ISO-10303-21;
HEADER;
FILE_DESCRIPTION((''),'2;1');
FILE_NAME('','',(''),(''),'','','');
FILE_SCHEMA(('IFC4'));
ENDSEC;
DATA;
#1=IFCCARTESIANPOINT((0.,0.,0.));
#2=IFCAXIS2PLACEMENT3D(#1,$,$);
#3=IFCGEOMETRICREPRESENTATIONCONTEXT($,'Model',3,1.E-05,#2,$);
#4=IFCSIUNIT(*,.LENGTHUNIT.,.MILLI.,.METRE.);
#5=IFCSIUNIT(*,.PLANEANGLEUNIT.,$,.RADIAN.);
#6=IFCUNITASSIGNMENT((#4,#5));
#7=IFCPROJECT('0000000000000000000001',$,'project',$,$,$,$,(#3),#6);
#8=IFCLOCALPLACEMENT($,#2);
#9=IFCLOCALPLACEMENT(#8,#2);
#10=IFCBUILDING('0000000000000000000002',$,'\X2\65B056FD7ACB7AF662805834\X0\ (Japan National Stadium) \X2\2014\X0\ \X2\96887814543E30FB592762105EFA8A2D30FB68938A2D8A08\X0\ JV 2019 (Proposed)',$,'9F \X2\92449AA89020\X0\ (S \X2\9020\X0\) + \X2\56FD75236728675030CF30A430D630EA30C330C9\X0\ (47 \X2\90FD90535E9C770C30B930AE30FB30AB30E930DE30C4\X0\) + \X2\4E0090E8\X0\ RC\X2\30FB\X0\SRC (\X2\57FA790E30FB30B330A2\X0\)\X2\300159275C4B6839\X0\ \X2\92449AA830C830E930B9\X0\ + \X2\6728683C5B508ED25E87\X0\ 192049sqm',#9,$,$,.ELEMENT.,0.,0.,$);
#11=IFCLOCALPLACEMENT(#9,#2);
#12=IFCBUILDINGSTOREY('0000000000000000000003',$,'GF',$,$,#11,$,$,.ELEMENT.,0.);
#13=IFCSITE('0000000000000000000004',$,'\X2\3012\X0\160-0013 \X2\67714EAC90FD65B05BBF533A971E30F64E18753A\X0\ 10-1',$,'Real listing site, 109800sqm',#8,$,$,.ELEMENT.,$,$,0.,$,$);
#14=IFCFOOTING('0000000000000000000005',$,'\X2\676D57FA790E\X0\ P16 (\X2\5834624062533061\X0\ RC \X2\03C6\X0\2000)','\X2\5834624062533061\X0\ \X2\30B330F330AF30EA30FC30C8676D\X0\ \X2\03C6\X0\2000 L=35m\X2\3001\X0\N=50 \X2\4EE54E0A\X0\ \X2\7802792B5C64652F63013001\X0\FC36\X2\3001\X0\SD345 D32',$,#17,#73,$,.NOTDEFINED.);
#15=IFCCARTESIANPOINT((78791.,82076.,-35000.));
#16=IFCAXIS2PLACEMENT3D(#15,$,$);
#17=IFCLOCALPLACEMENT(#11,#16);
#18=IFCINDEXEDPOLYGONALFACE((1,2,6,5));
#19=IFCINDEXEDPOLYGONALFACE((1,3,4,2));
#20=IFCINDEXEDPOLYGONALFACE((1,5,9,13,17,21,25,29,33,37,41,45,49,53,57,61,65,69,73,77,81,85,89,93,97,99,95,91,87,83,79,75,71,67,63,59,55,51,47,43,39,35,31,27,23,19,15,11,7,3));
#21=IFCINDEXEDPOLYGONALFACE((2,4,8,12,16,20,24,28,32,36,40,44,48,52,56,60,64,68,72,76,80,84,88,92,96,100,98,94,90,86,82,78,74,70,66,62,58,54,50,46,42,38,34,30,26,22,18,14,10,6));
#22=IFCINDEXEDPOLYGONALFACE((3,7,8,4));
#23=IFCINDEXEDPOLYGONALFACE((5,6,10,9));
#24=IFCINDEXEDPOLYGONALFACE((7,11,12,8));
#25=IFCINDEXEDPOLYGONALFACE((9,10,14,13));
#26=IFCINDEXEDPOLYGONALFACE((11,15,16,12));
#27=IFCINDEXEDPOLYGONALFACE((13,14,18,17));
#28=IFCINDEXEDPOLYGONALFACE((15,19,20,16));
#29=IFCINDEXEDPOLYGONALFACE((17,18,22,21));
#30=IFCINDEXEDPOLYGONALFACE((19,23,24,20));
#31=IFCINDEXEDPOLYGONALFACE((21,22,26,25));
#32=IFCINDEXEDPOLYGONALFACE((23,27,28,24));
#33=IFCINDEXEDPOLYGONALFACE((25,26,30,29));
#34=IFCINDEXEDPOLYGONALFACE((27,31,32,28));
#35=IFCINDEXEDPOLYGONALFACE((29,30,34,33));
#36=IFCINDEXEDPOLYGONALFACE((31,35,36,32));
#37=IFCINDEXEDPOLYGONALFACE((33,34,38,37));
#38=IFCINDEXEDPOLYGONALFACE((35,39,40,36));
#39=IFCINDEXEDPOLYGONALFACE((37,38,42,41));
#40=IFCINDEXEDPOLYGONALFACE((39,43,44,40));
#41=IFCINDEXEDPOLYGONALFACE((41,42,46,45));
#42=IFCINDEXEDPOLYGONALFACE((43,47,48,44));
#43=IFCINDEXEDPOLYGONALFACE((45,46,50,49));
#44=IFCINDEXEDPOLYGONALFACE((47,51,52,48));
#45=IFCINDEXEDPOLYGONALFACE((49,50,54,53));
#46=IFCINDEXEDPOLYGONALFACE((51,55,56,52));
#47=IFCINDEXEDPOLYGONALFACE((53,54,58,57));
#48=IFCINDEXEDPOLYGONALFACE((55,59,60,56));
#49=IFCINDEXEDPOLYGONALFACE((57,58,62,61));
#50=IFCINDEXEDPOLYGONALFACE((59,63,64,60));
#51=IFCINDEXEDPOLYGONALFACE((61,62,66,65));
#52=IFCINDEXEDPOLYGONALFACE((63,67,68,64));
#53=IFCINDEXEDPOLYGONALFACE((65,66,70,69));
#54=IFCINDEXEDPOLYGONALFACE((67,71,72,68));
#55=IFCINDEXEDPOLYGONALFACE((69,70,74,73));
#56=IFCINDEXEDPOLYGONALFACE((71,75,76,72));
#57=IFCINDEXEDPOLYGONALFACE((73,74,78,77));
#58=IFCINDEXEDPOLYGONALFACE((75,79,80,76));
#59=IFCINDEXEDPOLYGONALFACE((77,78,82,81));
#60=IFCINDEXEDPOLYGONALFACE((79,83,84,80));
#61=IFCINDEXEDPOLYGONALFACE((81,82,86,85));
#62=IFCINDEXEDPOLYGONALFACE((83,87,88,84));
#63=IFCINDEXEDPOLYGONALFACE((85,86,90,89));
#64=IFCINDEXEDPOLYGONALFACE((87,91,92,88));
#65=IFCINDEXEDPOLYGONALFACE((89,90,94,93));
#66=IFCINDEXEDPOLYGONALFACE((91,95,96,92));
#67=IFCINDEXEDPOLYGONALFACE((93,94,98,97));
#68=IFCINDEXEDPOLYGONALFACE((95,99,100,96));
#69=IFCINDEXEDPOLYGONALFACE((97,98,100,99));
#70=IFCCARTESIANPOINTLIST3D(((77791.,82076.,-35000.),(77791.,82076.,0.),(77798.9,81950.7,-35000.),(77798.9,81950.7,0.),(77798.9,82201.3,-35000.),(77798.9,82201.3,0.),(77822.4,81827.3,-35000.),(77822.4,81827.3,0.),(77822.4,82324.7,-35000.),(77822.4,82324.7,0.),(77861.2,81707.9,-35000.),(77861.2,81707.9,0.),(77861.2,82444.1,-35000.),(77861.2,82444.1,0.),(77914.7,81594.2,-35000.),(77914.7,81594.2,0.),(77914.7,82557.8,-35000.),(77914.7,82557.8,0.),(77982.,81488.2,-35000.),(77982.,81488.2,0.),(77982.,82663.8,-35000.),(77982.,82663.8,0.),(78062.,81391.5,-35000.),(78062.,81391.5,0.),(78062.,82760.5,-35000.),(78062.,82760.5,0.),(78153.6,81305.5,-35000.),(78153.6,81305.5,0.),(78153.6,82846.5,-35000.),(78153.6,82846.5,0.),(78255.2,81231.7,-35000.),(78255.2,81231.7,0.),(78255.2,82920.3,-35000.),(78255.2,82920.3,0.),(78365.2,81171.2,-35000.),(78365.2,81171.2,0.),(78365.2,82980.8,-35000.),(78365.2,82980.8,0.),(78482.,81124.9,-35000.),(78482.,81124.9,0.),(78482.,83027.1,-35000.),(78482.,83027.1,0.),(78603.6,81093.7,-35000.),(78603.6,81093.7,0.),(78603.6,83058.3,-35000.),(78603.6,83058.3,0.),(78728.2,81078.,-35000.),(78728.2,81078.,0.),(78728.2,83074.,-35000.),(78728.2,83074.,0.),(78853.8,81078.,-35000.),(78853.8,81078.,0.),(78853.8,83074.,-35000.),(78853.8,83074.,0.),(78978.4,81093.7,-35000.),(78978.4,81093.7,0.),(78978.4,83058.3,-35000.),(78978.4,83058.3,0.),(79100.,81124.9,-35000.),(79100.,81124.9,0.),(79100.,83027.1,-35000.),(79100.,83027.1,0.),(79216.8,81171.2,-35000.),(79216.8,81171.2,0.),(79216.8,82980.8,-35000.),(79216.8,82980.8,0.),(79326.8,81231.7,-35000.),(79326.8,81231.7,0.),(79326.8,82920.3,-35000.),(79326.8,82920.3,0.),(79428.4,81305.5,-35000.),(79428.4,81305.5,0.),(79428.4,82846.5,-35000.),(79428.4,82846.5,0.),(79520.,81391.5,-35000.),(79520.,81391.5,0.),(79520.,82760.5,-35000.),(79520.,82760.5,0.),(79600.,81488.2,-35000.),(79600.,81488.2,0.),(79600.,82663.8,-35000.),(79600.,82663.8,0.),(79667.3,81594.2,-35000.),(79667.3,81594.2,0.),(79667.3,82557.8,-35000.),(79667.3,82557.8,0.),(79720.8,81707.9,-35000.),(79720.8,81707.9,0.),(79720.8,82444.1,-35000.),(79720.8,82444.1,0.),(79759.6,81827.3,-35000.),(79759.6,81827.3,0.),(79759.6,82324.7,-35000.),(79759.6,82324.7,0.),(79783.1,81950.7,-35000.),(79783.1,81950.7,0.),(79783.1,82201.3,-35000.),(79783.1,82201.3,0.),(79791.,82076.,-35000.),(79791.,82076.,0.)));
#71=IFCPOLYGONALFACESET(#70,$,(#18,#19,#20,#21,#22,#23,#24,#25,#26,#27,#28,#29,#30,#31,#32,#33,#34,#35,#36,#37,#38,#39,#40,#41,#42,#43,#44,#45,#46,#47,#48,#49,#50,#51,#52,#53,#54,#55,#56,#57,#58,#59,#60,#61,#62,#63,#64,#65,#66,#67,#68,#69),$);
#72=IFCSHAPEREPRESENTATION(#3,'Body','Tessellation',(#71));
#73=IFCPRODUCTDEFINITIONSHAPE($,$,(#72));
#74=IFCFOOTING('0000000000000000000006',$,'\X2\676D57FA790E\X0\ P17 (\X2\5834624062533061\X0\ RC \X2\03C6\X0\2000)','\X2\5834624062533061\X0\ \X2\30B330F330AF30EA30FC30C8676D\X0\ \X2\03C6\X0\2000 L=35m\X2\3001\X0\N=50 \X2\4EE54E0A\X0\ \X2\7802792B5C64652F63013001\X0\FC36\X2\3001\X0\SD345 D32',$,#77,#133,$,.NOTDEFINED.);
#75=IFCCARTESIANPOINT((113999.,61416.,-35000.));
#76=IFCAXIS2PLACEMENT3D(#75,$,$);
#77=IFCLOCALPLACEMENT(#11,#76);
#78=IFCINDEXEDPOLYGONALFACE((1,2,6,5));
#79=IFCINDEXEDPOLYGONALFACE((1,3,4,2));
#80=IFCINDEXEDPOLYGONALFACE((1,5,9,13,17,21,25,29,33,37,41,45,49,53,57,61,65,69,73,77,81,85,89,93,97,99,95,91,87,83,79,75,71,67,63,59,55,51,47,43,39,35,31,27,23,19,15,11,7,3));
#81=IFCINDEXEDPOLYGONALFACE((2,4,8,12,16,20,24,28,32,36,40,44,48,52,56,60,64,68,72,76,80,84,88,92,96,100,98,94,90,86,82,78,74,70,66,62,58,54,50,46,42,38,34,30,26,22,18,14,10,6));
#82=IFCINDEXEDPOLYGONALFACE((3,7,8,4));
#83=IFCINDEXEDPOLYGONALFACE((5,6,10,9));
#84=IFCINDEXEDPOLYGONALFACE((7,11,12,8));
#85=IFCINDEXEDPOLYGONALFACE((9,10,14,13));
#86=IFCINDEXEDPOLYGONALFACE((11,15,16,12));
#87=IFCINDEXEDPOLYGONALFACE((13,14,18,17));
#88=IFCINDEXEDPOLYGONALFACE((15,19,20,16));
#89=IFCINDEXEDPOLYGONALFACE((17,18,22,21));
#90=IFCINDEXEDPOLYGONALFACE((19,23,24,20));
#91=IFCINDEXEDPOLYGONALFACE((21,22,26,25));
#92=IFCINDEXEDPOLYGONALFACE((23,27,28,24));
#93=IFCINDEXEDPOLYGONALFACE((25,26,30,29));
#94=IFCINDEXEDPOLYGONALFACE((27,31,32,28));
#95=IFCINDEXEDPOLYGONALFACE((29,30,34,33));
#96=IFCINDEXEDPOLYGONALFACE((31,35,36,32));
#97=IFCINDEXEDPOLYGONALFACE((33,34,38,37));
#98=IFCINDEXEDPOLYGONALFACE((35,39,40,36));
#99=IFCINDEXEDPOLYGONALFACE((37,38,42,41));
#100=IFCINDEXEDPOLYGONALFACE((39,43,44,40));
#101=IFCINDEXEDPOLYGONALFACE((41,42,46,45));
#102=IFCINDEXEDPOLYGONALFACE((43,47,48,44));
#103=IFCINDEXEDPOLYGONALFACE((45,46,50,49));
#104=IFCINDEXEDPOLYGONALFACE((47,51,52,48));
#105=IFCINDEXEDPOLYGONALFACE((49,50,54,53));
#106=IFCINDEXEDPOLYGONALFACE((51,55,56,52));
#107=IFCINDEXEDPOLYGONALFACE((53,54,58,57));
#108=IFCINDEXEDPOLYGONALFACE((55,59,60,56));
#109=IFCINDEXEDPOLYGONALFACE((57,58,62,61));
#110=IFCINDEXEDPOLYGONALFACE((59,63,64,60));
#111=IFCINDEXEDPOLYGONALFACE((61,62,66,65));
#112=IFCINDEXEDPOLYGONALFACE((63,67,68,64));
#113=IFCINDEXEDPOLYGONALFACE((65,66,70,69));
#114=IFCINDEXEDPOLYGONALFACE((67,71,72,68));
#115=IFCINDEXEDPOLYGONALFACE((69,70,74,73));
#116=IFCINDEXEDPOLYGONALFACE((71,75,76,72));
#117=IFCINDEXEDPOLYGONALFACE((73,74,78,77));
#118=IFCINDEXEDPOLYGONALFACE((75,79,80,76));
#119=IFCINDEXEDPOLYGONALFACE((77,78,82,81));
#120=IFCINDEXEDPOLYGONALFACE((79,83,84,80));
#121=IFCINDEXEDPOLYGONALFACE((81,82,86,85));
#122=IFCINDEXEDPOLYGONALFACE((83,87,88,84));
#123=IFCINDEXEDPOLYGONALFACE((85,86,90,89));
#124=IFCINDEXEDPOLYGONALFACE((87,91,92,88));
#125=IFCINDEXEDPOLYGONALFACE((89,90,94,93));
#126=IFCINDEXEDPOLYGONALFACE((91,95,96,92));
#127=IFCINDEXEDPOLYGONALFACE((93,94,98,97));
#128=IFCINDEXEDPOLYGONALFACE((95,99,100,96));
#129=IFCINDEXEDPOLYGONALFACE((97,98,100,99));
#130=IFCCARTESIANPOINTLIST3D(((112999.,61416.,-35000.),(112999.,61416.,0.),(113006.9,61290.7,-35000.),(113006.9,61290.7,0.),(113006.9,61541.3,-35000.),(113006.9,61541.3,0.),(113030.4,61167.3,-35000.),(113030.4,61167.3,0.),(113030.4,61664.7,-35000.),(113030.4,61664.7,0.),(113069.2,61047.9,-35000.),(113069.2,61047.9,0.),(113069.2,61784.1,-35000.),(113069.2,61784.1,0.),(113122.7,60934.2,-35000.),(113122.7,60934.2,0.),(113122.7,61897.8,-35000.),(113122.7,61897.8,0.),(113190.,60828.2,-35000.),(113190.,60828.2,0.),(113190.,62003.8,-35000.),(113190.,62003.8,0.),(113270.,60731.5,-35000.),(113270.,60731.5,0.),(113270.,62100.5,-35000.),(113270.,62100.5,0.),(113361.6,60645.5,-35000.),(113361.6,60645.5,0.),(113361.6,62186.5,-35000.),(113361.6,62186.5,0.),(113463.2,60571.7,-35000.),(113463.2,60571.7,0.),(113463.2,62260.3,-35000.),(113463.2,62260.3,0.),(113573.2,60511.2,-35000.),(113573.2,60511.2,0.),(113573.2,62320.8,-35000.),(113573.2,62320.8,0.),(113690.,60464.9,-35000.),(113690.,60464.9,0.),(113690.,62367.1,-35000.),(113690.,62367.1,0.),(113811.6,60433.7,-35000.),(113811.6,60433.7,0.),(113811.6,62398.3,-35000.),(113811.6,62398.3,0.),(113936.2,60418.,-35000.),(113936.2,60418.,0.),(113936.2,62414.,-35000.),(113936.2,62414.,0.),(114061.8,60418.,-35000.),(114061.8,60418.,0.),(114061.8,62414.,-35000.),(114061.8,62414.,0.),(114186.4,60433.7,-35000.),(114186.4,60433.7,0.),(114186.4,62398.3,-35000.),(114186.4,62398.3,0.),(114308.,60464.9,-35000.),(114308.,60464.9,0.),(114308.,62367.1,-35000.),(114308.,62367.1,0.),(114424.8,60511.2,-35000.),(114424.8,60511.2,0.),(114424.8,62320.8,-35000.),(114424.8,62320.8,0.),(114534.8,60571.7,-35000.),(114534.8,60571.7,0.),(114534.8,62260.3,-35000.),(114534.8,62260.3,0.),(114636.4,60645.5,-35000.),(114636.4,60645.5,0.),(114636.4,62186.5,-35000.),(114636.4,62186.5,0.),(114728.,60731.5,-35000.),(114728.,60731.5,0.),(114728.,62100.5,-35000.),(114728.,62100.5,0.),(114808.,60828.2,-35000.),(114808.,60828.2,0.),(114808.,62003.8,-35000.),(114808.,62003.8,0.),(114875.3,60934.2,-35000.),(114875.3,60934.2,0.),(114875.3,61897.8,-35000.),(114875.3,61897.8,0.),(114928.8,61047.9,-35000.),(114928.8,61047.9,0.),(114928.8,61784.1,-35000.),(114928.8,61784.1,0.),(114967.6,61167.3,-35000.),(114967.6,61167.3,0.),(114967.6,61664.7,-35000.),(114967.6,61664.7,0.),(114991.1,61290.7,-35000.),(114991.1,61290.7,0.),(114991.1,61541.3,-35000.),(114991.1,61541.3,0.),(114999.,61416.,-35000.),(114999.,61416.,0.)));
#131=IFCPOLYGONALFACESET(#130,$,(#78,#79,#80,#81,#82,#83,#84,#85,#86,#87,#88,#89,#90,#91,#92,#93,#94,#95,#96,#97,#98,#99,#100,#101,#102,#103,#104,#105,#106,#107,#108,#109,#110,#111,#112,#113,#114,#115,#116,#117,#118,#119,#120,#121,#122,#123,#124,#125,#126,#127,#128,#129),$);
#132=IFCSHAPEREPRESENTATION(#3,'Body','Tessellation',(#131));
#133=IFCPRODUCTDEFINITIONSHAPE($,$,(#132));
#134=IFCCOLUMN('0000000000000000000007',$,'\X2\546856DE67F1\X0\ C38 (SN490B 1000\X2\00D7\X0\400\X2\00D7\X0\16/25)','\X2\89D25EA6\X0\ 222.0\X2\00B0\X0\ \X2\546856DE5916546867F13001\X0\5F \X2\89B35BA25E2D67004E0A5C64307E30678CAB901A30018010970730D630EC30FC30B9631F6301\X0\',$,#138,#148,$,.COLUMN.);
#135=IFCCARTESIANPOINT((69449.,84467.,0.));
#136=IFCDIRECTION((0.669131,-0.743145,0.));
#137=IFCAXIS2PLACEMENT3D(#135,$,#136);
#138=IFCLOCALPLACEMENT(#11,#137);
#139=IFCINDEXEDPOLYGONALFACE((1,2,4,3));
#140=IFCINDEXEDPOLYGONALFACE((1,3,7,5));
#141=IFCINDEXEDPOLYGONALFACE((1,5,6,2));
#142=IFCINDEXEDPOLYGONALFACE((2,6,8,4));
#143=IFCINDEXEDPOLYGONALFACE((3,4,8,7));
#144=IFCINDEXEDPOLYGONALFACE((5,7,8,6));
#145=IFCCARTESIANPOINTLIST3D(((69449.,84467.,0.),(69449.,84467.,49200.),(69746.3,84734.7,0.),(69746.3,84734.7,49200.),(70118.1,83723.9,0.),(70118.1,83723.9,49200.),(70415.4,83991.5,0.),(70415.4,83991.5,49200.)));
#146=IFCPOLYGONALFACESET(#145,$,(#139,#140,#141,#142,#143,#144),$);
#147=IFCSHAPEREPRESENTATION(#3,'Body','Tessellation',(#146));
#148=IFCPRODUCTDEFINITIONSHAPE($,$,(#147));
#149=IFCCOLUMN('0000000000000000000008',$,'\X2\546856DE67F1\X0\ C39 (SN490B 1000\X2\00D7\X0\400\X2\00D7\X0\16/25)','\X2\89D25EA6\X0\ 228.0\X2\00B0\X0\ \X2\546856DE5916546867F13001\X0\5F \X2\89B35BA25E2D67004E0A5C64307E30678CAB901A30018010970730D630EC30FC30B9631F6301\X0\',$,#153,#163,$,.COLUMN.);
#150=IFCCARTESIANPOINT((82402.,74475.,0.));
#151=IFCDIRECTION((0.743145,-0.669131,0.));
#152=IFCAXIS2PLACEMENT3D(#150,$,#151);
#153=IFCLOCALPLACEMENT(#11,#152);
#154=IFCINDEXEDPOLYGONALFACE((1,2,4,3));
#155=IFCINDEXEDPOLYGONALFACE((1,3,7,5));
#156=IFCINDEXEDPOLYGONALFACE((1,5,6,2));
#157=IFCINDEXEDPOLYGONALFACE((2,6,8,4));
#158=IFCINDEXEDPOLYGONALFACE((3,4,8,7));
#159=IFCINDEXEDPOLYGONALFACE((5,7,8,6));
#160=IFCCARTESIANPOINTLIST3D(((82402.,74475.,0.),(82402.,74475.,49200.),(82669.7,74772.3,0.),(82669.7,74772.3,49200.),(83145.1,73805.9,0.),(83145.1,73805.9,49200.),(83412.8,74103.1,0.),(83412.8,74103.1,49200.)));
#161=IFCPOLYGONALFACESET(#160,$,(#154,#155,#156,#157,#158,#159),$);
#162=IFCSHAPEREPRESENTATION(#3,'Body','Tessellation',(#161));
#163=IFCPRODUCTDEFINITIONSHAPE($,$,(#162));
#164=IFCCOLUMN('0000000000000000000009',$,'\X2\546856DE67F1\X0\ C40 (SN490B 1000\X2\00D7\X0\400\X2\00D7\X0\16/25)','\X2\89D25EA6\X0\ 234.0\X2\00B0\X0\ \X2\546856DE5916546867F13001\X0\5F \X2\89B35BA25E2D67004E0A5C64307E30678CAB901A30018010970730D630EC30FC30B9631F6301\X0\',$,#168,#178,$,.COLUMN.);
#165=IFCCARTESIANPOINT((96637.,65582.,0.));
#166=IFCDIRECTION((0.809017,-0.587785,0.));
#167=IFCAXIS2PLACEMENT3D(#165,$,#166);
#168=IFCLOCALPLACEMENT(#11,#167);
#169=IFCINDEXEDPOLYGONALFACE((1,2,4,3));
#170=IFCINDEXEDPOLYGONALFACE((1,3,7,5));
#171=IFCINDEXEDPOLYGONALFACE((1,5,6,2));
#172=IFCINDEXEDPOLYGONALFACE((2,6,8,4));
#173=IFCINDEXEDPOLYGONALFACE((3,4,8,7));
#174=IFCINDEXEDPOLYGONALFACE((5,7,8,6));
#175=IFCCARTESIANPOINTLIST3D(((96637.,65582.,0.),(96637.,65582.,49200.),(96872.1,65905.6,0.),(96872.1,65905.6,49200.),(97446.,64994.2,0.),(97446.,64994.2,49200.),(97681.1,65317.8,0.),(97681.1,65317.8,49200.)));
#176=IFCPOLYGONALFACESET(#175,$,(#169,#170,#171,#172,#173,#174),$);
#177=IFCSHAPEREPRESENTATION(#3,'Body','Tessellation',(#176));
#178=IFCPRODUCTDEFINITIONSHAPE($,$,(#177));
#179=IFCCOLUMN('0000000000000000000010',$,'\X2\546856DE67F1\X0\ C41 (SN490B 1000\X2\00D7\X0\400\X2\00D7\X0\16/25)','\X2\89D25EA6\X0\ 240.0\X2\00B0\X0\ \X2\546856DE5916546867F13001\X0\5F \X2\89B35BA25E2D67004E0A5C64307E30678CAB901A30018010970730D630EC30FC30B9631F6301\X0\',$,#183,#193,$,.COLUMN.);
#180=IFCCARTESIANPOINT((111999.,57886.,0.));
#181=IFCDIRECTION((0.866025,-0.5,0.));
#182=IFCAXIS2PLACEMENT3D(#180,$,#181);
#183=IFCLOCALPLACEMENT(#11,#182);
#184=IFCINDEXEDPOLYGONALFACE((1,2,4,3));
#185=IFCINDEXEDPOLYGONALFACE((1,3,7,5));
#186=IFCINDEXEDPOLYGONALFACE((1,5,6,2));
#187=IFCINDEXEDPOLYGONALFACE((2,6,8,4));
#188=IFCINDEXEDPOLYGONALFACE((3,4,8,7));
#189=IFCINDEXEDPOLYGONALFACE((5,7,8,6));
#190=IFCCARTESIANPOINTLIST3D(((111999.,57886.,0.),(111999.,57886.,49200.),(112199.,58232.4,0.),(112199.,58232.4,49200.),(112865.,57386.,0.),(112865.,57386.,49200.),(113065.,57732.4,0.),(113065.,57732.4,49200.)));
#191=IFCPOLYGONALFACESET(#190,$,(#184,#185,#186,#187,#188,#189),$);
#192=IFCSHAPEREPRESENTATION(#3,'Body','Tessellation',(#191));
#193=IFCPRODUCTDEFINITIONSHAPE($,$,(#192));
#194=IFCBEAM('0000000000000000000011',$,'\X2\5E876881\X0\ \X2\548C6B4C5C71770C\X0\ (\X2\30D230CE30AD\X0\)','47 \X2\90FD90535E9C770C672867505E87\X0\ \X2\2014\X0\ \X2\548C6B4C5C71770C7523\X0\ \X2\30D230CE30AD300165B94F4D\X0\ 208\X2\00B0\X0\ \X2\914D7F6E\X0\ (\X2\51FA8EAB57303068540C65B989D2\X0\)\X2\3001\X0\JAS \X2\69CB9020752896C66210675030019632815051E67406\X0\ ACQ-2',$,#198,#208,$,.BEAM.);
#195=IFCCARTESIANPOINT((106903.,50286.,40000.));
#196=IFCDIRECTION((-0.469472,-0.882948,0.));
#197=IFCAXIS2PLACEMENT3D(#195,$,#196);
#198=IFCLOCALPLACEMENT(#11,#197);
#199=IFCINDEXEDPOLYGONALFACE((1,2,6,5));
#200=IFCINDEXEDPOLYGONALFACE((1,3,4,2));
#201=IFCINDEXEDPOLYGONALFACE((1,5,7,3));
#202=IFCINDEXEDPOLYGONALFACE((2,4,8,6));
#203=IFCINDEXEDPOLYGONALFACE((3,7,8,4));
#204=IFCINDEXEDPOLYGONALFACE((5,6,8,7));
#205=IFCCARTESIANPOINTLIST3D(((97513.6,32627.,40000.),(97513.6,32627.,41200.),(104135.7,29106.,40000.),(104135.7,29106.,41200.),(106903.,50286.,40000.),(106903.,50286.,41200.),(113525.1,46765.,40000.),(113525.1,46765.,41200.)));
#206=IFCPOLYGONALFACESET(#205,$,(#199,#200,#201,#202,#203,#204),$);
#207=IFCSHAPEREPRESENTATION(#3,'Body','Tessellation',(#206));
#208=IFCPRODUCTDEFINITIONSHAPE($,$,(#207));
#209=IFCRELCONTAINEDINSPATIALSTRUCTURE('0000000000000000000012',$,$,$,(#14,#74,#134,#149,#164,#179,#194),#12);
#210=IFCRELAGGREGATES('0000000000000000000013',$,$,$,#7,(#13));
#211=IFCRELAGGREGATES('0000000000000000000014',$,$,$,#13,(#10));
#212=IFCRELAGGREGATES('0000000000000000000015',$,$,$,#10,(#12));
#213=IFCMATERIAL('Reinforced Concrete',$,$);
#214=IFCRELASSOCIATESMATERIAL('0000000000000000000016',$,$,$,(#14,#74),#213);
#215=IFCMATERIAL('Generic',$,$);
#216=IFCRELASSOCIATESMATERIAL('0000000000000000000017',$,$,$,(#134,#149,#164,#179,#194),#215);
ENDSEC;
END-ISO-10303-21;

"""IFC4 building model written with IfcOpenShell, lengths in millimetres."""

from ifc_helpers import new_model, si_unit, frame, frame_2d, origin, origin_2d, place, context, project, spatial, rectangle, circle, extrude, material, element, save


model = new_model("IFC4")

# Units and contexts
model_context = context("Model", 3, precision=1e-05, world=origin())
ifc_project = project(units=[si_unit("LENGTHUNIT", "METRE", prefix="MILLI"), si_unit("PLANEANGLEUNIT", "RADIAN")], contexts=[model_context])

# Site, building, storey
site_placement = place(None, origin())
site = spatial("IfcSite", under=ifc_project, at=site_placement, Name="〒160-0013 東京都新宿区霞ヶ丘町 10-1", ObjectType="Real listing site, 109800sqm", CompositionType="ELEMENT", RefElevation=0.0)
building_placement = place(site_placement, origin())
building = spatial("IfcBuilding", under=site, at=building_placement, Name="新国立競技場 (Japan National Stadium) — 隈研吾・大成建設・梓設計 JV 2019 (Proposed)", ObjectType="9F 鉄骨造 (S 造) + 国産木材ハイブリッド (47 都道府県スギ・カラマツ) + 一部 RC・SRC (基礎・コア)、大屋根 鉄骨トラス + 木格子軒庇 192049sqm", CompositionType="ELEMENT", ElevationOfRefHeight=0.0, ElevationOfTerrain=0.0)
storey_placement = place(building_placement, origin())
storey = spatial("IfcBuildingStorey", under=building, at=storey_placement, Name="GF", CompositionType="ELEMENT", Elevation=0.0)

# Footings
ifc_material_1 = material(Name="Reinforced Concrete")
footing_1_placement = place(storey_placement, frame((78791.0, 82076.0, -35000.0)))
element("IfcFooting", 1, at=footing_1_placement, inside=storey, material=ifc_material_1, Name="杭基礎 P16 (場所打ち RC φ2000)", Description="場所打ち コンクリート杭 φ2000 L=35m、N=50 以上 砂礫層支持、FC36、SD345 D32", PredefinedType="NOTDEFINED", context=model_context, shape_type="SweptSolid", body=[
    extrude(circle(Radius=1000.0, at=origin_2d()), frame((78791.0, 82076.0, -35000.0)), (0.0, 0.0, 1.0), 35000.0),
])
footing_2_placement = place(storey_placement, frame((113999.0, 61416.0, -35000.0)))
element("IfcFooting", 2, at=footing_2_placement, inside=storey, material=ifc_material_1, Name="杭基礎 P17 (場所打ち RC φ2000)", Description="場所打ち コンクリート杭 φ2000 L=35m、N=50 以上 砂礫層支持、FC36、SD345 D32", PredefinedType="NOTDEFINED", context=model_context, shape_type="SweptSolid", body=[
    extrude(circle(Radius=1000.0, at=origin_2d()), frame((113999.0, 61416.0, -35000.0)), (0.0, 0.0, 1.0), 35000.0),
])

# Columns
ifc_material_2 = material(Name="Generic")
column_1_placement = place(storey_placement, frame((69449.0, 84467.0, 0.0), x_axis=(0.669131, -0.743145, 0.0)))
element("IfcColumn", 3, at=column_1_placement, inside=storey, material=ifc_material_2, Name="周回柱 C38 (SN490B 1000×400×16/25)", Description="角度 222.0° 周回外周柱、5F 観客席最上層まで貫通、耐震ブレース挟持", PredefinedType="COLUMN", context=model_context, shape_type="SweptSolid", body=[
    extrude(rectangle(XDim=1000.0, YDim=400.0, at=frame_2d((500.0, 200.0))), frame((69449.0, 84467.0, 0.0), x_axis=(0.669131, -0.743145, 0.0)), (0.0, 0.0, 1.0), 49200.0),
])
column_2_placement = place(storey_placement, frame((82402.0, 74475.0, 0.0), x_axis=(0.743145, -0.669131, 0.0)))
element("IfcColumn", 4, at=column_2_placement, inside=storey, material=ifc_material_2, Name="周回柱 C39 (SN490B 1000×400×16/25)", Description="角度 228.0° 周回外周柱、5F 観客席最上層まで貫通、耐震ブレース挟持", PredefinedType="COLUMN", context=model_context, shape_type="SweptSolid", body=[
    extrude(rectangle(XDim=1000.0, YDim=400.0, at=frame_2d((500.0, 200.0))), frame((82402.0, 74475.0, 0.0), x_axis=(0.743145, -0.669131, 0.0)), (0.0, 0.0, 1.0), 49200.0),
])
column_3_placement = place(storey_placement, frame((96637.0, 65582.0, 0.0), x_axis=(0.809017, -0.587785, 0.0)))
element("IfcColumn", 5, at=column_3_placement, inside=storey, material=ifc_material_2, Name="周回柱 C40 (SN490B 1000×400×16/25)", Description="角度 234.0° 周回外周柱、5F 観客席最上層まで貫通、耐震ブレース挟持", PredefinedType="COLUMN", context=model_context, shape_type="SweptSolid", body=[
    extrude(rectangle(XDim=1000.0, YDim=400.0, at=frame_2d((500.0, 200.0))), frame((96637.0, 65582.0, 0.0), x_axis=(0.809017, -0.587785, 0.0)), (0.0, 0.0, 1.0), 49200.0),
])
column_4_placement = place(storey_placement, frame((111999.0, 57886.0, 0.0), x_axis=(0.866025, -0.5, 0.0)))
element("IfcColumn", 6, at=column_4_placement, inside=storey, material=ifc_material_2, Name="周回柱 C41 (SN490B 1000×400×16/25)", Description="角度 240.0° 周回外周柱、5F 観客席最上層まで貫通、耐震ブレース挟持", PredefinedType="COLUMN", context=model_context, shape_type="SweptSolid", body=[
    extrude(rectangle(XDim=1000.0, YDim=400.0, at=frame_2d((500.0, 200.0))), frame((111999.0, 57886.0, 0.0), x_axis=(0.866025, -0.5, 0.0)), (0.0, 0.0, 1.0), 49200.0),
])

# Beam
beam_1_placement = place(storey_placement, frame((106903.0, 50286.0, 40000.0), x_axis=(-0.469472, -0.882948, 0.0)))
element("IfcBeam", 7, at=beam_1_placement, inside=storey, material=ifc_material_2, Name="庇梁 和歌山県 (ヒノキ)", Description="47 都道府県木材庇 — 和歌山県産 ヒノキ、方位 208° 配置 (出身地と同方角)、JAS 構造用集成材、防腐処理 ACQ-2", PredefinedType="BEAM", context=model_context, shape_type="SweptSolid", body=[
    extrude(rectangle(XDim=20000.0, YDim=7500.0, at=frame_2d((10000.0, 3750.0))), frame((106903.0, 50286.0, 40000.0), x_axis=(-0.469472, -0.882948, 0.0)), (0.0, 0.0, 1.0), 1200.0),
])

save(model, "model.ifc")
